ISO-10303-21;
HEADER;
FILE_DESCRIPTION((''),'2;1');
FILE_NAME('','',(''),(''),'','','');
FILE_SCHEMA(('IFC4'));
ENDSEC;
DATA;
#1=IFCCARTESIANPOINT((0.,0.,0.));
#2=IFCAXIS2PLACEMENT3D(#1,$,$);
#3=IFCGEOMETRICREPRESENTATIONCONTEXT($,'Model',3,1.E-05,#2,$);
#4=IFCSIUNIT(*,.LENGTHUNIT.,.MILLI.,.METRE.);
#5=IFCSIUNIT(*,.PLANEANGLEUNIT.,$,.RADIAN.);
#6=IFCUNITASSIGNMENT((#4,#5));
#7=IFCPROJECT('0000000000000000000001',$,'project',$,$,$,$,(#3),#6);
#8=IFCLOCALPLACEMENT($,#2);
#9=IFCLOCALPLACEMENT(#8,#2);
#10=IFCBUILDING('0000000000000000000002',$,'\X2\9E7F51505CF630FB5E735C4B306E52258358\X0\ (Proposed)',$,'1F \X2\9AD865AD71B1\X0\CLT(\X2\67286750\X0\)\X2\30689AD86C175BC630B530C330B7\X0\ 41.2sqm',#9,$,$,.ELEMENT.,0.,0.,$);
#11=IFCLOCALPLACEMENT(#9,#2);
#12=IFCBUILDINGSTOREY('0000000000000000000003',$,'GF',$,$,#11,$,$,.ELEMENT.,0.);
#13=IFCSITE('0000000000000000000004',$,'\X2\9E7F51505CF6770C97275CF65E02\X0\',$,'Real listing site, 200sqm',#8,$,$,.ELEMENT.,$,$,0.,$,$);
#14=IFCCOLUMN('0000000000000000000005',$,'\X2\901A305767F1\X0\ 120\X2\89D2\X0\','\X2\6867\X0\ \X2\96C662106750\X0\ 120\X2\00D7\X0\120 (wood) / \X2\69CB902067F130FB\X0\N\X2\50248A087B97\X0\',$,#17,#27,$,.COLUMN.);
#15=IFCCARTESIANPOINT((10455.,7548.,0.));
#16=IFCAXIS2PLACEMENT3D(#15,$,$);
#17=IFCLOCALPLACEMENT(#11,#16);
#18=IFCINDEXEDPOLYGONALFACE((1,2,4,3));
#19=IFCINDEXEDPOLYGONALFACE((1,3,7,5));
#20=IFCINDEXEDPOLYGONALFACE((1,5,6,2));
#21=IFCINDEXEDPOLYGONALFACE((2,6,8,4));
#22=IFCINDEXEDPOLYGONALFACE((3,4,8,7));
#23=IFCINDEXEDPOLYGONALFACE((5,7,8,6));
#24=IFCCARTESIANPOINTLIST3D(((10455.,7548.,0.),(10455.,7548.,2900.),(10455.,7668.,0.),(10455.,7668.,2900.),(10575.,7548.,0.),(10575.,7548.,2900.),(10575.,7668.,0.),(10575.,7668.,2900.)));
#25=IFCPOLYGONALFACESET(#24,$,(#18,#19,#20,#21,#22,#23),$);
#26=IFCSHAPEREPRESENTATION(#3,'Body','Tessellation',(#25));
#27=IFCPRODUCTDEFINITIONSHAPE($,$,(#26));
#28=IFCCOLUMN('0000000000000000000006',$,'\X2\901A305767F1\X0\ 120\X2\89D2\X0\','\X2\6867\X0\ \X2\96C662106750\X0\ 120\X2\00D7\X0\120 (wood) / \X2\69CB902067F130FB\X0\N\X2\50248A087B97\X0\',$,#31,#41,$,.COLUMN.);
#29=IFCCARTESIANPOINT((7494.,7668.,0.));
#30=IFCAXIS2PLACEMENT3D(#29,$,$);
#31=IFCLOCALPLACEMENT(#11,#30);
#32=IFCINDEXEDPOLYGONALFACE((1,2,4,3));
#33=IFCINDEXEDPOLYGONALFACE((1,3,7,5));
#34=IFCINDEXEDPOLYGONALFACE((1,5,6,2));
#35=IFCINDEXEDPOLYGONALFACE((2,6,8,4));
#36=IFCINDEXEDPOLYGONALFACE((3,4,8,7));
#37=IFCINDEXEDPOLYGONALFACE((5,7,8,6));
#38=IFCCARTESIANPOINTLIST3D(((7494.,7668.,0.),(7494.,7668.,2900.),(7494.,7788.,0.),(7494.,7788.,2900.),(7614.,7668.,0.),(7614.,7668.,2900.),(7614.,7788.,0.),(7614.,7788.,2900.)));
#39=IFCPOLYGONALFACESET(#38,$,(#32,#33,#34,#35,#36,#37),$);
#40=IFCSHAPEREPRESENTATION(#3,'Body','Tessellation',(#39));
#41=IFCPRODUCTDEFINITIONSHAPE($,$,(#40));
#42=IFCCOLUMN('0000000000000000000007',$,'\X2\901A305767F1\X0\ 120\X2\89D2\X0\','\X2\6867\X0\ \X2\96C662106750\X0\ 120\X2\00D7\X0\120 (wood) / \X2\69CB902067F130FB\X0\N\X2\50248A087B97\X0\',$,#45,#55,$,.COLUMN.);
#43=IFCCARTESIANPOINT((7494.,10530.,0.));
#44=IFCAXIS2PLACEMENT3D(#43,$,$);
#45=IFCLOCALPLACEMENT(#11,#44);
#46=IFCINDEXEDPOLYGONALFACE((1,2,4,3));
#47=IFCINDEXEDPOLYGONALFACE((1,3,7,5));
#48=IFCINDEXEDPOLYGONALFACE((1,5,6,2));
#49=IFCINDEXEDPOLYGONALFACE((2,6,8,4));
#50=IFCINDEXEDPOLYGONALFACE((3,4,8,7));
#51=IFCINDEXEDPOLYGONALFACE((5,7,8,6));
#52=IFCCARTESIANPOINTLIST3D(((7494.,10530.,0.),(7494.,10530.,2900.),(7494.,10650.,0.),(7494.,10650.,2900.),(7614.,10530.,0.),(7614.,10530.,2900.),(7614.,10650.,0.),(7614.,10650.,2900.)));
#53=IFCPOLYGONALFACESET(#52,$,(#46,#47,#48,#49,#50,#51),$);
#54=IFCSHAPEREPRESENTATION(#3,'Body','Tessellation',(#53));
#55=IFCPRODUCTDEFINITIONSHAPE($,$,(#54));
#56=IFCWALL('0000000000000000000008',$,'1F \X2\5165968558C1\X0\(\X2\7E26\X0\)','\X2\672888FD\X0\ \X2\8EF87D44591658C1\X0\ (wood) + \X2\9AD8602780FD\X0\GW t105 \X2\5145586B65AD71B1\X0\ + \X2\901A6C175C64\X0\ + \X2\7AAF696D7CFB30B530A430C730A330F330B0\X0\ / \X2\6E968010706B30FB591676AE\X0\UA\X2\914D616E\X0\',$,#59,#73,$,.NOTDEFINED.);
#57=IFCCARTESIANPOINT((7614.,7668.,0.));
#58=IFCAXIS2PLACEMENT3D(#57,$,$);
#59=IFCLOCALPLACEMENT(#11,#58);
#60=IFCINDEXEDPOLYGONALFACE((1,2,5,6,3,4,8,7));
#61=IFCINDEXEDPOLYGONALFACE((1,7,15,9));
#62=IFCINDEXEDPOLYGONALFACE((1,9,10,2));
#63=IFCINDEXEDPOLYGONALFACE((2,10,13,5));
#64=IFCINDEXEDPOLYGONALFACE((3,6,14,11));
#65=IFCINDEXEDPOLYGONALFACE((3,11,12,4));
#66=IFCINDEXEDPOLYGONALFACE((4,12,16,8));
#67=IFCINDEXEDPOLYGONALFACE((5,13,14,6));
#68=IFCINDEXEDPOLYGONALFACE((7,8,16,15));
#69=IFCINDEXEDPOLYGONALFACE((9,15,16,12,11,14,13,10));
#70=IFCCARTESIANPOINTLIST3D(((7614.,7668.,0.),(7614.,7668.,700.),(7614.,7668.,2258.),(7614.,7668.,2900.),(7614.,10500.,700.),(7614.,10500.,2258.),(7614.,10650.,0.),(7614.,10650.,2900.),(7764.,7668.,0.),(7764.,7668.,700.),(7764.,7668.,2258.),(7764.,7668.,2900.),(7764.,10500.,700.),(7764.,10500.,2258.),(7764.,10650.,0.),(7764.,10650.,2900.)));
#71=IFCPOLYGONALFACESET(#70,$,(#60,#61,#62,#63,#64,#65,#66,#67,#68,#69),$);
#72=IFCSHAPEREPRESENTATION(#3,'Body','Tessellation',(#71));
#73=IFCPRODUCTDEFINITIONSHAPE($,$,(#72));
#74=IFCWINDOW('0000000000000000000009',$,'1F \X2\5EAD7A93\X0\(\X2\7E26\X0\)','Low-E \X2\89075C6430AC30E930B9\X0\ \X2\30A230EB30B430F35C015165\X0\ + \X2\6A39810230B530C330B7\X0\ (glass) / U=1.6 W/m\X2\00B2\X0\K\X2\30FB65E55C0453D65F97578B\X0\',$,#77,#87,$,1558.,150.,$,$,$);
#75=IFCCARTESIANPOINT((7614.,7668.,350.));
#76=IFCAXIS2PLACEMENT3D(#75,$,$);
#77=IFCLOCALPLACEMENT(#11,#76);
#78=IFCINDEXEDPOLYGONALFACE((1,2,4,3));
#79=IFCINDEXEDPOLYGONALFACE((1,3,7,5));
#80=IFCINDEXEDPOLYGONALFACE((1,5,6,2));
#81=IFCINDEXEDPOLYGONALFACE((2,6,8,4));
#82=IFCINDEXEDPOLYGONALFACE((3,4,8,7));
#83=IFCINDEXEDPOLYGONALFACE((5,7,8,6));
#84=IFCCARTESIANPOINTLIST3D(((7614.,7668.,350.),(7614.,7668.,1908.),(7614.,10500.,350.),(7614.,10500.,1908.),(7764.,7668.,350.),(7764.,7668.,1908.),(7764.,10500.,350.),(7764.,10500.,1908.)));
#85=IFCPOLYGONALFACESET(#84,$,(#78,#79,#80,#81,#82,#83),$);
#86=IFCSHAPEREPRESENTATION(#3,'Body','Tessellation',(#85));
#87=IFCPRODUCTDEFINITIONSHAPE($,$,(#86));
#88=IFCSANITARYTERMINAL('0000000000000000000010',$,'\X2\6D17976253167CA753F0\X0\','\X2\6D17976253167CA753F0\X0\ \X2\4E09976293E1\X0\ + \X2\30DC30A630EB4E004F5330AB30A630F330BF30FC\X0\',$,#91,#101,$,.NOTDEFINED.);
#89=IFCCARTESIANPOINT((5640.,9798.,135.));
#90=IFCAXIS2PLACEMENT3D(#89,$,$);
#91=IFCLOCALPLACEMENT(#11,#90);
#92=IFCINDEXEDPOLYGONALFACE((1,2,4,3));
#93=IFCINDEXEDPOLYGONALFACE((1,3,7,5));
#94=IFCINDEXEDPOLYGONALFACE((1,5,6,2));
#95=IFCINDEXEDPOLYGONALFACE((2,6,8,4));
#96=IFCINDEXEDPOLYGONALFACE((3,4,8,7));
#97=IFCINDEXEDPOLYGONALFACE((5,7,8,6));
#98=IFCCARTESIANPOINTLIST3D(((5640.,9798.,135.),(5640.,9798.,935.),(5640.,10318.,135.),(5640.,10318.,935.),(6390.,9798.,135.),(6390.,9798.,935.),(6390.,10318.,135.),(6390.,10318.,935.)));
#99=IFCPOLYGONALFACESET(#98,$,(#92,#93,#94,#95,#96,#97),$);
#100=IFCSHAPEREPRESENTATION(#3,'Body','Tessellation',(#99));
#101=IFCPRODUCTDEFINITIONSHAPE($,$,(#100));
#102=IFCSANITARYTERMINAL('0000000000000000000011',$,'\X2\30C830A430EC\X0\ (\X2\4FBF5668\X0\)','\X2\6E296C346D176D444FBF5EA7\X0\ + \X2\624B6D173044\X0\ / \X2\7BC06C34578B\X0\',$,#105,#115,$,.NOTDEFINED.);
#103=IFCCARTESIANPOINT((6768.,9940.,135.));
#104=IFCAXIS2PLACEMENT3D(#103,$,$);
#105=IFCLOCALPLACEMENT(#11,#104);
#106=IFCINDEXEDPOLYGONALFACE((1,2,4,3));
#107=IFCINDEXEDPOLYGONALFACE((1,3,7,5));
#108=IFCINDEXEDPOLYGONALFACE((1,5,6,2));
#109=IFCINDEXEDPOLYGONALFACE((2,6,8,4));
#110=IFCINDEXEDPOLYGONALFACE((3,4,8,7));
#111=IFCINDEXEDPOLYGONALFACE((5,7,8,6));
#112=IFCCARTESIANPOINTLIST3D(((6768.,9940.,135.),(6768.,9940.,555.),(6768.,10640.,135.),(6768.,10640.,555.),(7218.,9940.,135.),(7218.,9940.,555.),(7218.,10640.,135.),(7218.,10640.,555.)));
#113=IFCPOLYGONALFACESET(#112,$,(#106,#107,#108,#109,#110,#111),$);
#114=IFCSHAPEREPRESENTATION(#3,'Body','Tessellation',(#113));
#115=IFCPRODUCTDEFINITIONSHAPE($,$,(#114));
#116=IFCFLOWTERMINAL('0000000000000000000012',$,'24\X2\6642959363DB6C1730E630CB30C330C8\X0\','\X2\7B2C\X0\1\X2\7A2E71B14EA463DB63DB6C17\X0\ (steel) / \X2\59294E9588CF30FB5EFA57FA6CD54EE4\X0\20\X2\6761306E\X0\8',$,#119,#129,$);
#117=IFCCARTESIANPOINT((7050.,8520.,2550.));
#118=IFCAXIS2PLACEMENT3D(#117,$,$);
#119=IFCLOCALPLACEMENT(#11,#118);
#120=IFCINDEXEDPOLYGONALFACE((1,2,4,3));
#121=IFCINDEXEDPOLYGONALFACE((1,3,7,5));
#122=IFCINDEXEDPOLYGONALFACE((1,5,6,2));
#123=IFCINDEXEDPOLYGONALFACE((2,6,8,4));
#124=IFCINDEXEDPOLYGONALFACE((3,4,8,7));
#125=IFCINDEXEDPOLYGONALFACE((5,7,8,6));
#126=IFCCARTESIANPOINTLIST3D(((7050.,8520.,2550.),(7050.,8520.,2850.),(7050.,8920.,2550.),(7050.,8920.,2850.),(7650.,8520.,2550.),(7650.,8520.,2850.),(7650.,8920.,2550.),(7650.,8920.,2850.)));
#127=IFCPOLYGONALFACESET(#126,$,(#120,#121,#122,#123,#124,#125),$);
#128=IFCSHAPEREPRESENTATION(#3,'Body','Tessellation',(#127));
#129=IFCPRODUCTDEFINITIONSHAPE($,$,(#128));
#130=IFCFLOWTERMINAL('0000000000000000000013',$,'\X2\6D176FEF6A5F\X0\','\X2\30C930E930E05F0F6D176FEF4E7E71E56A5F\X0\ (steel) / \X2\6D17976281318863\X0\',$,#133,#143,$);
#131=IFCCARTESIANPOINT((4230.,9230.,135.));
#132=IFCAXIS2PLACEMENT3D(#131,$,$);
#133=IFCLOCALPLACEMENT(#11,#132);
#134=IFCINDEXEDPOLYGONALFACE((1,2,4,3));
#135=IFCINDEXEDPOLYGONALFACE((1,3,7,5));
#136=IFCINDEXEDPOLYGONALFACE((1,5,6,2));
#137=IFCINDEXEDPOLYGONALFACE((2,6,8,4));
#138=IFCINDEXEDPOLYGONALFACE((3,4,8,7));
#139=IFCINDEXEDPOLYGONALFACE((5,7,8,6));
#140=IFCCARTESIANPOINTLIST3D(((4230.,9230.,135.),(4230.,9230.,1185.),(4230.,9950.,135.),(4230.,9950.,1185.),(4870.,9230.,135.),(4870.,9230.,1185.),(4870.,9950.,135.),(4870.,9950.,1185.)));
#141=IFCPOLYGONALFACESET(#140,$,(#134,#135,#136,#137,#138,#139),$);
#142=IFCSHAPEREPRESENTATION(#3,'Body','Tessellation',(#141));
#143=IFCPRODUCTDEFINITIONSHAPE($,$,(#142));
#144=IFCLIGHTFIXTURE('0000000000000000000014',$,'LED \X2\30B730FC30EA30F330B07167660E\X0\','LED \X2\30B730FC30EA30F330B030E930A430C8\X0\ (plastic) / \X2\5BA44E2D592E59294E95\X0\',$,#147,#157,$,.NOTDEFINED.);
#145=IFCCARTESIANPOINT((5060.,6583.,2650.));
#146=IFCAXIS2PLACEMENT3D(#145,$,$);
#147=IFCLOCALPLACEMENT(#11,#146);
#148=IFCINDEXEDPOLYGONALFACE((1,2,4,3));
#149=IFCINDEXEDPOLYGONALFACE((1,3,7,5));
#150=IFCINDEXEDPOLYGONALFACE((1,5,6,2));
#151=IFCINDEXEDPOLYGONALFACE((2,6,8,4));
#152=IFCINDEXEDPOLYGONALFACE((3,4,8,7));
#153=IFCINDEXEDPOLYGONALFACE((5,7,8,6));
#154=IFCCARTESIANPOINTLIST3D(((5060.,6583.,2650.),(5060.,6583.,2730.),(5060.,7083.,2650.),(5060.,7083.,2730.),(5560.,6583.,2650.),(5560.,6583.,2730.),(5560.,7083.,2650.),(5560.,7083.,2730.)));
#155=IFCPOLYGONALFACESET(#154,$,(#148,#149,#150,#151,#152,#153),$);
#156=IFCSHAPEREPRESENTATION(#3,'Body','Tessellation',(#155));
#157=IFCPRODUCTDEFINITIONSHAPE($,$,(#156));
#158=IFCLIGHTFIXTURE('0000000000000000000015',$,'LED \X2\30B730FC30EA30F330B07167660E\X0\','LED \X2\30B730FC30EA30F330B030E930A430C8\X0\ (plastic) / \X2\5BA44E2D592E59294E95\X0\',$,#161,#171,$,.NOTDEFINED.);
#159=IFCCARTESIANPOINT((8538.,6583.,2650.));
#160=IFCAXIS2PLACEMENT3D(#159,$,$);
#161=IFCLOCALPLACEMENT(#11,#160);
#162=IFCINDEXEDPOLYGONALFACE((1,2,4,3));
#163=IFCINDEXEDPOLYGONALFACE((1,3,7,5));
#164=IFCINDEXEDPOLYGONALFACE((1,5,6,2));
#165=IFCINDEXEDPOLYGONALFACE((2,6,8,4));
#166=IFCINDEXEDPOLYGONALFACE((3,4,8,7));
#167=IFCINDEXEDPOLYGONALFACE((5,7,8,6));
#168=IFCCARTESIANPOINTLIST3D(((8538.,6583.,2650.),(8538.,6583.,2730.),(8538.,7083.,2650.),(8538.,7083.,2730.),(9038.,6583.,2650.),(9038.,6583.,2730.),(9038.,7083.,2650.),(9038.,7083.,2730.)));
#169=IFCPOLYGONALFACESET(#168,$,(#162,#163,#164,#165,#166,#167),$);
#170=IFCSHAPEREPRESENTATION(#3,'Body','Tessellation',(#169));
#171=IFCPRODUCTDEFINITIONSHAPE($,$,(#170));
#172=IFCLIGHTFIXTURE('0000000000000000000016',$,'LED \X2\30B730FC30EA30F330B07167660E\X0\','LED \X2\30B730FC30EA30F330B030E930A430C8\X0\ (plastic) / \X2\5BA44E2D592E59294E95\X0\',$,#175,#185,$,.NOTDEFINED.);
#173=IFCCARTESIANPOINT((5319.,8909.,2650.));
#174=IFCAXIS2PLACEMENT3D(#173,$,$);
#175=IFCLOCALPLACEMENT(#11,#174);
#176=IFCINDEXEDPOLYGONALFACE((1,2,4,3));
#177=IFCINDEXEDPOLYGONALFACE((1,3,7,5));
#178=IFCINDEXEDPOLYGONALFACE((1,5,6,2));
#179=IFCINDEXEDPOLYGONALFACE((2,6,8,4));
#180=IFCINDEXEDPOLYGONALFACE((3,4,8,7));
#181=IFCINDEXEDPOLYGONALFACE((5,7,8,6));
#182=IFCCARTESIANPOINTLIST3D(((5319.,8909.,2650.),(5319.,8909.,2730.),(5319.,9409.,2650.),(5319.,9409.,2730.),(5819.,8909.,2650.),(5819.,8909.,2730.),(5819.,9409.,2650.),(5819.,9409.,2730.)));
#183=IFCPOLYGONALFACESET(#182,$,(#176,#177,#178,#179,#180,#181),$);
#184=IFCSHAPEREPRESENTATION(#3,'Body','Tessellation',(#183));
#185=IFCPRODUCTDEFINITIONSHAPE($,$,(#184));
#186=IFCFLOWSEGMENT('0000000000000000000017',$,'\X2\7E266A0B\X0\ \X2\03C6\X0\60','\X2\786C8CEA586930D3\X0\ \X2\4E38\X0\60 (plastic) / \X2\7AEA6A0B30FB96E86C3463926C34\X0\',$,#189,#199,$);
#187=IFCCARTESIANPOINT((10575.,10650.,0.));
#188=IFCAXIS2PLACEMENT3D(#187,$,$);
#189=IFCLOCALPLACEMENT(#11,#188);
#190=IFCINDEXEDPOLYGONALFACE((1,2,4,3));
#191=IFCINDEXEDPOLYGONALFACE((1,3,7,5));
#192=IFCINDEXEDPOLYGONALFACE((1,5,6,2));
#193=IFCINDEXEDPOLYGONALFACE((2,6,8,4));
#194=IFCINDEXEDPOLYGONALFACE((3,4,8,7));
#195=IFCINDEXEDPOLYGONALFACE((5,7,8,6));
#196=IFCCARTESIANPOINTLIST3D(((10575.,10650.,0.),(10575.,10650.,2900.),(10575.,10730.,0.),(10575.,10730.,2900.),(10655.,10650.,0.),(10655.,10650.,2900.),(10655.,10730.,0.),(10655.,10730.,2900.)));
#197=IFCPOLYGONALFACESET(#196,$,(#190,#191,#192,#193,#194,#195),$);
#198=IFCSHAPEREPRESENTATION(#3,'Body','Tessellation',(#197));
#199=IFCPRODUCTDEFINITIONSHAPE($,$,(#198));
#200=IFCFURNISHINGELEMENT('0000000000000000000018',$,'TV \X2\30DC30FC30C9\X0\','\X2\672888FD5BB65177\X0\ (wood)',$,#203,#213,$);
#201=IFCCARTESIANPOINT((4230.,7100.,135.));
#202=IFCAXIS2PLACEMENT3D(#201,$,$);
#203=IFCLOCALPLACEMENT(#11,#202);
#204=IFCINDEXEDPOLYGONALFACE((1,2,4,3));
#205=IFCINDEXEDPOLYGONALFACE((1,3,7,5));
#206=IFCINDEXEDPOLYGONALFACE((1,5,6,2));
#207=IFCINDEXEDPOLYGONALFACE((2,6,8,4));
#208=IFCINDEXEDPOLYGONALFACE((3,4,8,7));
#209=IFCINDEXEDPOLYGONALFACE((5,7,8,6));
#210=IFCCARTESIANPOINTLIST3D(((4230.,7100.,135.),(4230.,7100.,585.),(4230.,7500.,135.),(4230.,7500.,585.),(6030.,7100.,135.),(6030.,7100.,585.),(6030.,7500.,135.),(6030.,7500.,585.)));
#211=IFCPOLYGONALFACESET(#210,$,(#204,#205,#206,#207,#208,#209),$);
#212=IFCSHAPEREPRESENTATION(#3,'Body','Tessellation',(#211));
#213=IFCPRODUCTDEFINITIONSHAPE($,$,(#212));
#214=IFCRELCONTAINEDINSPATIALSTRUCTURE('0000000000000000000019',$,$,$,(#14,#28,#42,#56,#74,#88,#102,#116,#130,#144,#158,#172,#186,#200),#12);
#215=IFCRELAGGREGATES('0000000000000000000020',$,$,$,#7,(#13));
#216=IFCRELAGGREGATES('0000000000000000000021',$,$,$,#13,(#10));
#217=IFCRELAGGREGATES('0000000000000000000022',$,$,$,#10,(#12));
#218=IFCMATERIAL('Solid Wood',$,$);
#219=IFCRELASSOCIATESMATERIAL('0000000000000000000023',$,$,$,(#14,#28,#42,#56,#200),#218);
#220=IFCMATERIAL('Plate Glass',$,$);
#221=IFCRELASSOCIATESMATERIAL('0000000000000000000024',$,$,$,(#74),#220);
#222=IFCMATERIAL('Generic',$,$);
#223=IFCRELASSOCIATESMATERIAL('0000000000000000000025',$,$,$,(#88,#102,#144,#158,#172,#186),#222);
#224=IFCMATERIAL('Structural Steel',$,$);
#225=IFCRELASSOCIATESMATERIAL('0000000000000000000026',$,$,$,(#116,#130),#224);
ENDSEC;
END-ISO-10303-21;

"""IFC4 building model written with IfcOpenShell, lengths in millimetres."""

from ifc_helpers import new_model, si_unit, frame, frame_2d, origin, place, context, project, spatial, rectangle, extrude, material, element, fill, save


model = new_model("IFC4")

# Units and contexts
model_context = context("Model", 3, precision=1e-05, world=origin())
ifc_project = project(units=[si_unit("LENGTHUNIT", "METRE", prefix="MILLI"), si_unit("PLANEANGLEUNIT", "RADIAN")], contexts=[model_context])

# Site, building, storey
site_placement = place(None, origin())
site = spatial("IfcSite", under=ifc_project, at=site_placement, Name="鹿児島県霧島市", ObjectType="Real listing site, 200sqm", CompositionType="ELEMENT", RefElevation=0.0)
building_placement = place(site_placement, origin())
building = spatial("IfcBuilding", under=site, at=building_placement, Name="鹿児島・平屋の別荘 (Proposed)", ObjectType="1F 高断熱CLT(木材)と高気密サッシ 41.2sqm", CompositionType="ELEMENT", ElevationOfRefHeight=0.0, ElevationOfTerrain=0.0)
storey_placement = place(building_placement, origin())
storey = spatial("IfcBuildingStorey", under=building, at=storey_placement, Name="GF", CompositionType="ELEMENT", Elevation=0.0)

# Columns
ifc_material_1 = material(Name="Solid Wood")
column_1_placement = place(storey_placement, frame((10455.0, 7548.0, 0.0)))
element("IfcColumn", 1, at=column_1_placement, inside=storey, material=ifc_material_1, Name="通し柱 120角", Description="桧 集成材 120×120 (wood) / 構造柱・N値計算", PredefinedType="COLUMN", context=model_context, shape_type="SweptSolid", body=[
    extrude(rectangle(XDim=120.0, YDim=120.0, at=frame_2d((60.0, 60.0))), frame((10455.0, 7548.0, 0.0)), (0.0, 0.0, 1.0), 2900.0),
])
column_2_placement = place(storey_placement, frame((7494.0, 7668.0, 0.0)))
element("IfcColumn", 2, at=column_2_placement, inside=storey, material=ifc_material_1, Name="通し柱 120角", Description="桧 集成材 120×120 (wood) / 構造柱・N値計算", PredefinedType="COLUMN", context=model_context, shape_type="SweptSolid", body=[
    extrude(rectangle(XDim=120.0, YDim=120.0, at=frame_2d((60.0, 60.0))), frame((7494.0, 7668.0, 0.0)), (0.0, 0.0, 1.0), 2900.0),
])
column_3_placement = place(storey_placement, frame((7494.0, 10530.0, 0.0)))
element("IfcColumn", 3, at=column_3_placement, inside=storey, material=ifc_material_1, Name="通し柱 120角", Description="桧 集成材 120×120 (wood) / 構造柱・N値計算", PredefinedType="COLUMN", context=model_context, shape_type="SweptSolid", body=[
    extrude(rectangle(XDim=120.0, YDim=120.0, at=frame_2d((60.0, 60.0))), frame((7494.0, 10530.0, 0.0)), (0.0, 0.0, 1.0), 2900.0),
])

# Wall, opening, window
wall_1_placement = place(storey_placement, frame((7614.0, 7668.0, 0.0)))
wall_1 = element("IfcWall", 4, at=wall_1_placement, inside=storey, material=ifc_material_1, Name="1F 入隅壁(縦)", Description="木製 軸組外壁 (wood) + 高性能GW t105 充填断熱 + 通気層 + 窯業系サイディング / 準耐火・外皮UA配慮", PredefinedType="NOTDEFINED", context=model_context, shape_type="SweptSolid", body=[
    extrude(rectangle(XDim=150.0, YDim=2982.0, at=frame_2d((75.0, 1491.0))), frame((7614.0, 7668.0, 0.0)), (0.0, 0.0, 1.0), 2900.0),
])
opening_placement = place(storey_placement, frame((7614.0, 7668.0, 350.0)))
opening = element("IfcOpeningElement", 5, at=opening_placement, cuts=wall_1, PredefinedType="NOTDEFINED", context=model_context, shape_type="SweptSolid", body=[
    extrude(rectangle(XDim=150.0, YDim=2832.0, at=frame_2d((75.0, 1416.0))), frame((7614.0, 7668.0, 350.0)), (0.0, 0.0, 1.0), 1558.0),
])
ifc_material_2 = material(Name="Plate Glass")
window_placement = place(storey_placement, frame((7614.0, 7668.0, 350.0)))
window = element("IfcWindow", 6, at=window_placement, inside=storey, material=ifc_material_2, Name="1F 庭窓(縦)", Description="Low-E 複層ガラス アルゴン封入 + 樹脂サッシ (glass) / U=1.6 W/m²K・日射取得型", OverallHeight=1558.0, OverallWidth=150.0, context=model_context, shape_type="SweptSolid", body=[
    extrude(rectangle(XDim=150.0, YDim=2832.0, at=frame_2d((75.0, 1416.0))), frame((7614.0, 7668.0, 350.0)), (0.0, 0.0, 1.0), 1558.0),
])
fill(opening, window)

# Sanitary terminals
ifc_material_3 = material(Name="Generic")
sanitary_terminal_1_placement = place(storey_placement, frame((5640.0, 9798.0, 135.0)))
element("IfcSanitaryTerminal", 7, at=sanitary_terminal_1_placement, inside=storey, material=ifc_material_3, Name="洗面化粧台", Description="洗面化粧台 三面鏡 + ボウル一体カウンター", PredefinedType="NOTDEFINED", context=model_context, shape_type="SweptSolid", body=[
    extrude(rectangle(XDim=750.0, YDim=520.0, at=frame_2d((375.0, 260.0))), frame((5640.0, 9798.0, 135.0)), (0.0, 0.0, 1.0), 800.0),
])
sanitary_terminal_2_placement = place(storey_placement, frame((6768.0, 9940.0, 135.0)))
element("IfcSanitaryTerminal", 8, at=sanitary_terminal_2_placement, inside=storey, material=ifc_material_3, Name="トイレ (便器)", Description="温水洗浄便座 + 手洗い / 節水型", PredefinedType="NOTDEFINED", context=model_context, shape_type="SweptSolid", body=[
    extrude(rectangle(XDim=450.0, YDim=700.0, at=frame_2d((225.0, 350.0))), frame((6768.0, 9940.0, 135.0)), (0.0, 0.0, 1.0), 420.0),
])

# Flow terminals
ifc_material_4 = material(Name="Structural Steel")
flow_terminal_1_placement = place(storey_placement, frame((7050.0, 8520.0, 2550.0)))
element("IfcFlowTerminal", 9, at=flow_terminal_1_placement, inside=storey, material=ifc_material_4, Name="24時間換気ユニット", Description="第1種熱交換換気 (steel) / 天井裏・建基法令20条の8", context=model_context, shape_type="SweptSolid", body=[
    extrude(rectangle(XDim=600.0, YDim=400.0, at=frame_2d((300.0, 200.0))), frame((7050.0, 8520.0, 2550.0)), (0.0, 0.0, 1.0), 300.0),
])
flow_terminal_2_placement = place(storey_placement, frame((4230.0, 9230.0, 135.0)))
element("IfcFlowTerminal", 10, at=flow_terminal_2_placement, inside=storey, material=ifc_material_4, Name="洗濯機", Description="ドラム式洗濯乾燥機 (steel) / 洗面脱衣", context=model_context, shape_type="SweptSolid", body=[
    extrude(rectangle(XDim=640.0, YDim=720.0, at=frame_2d((320.0, 360.0))), frame((4230.0, 9230.0, 135.0)), (0.0, 0.0, 1.0), 1050.0),
])

# Light fixtures
light_fixture_1_placement = place(storey_placement, frame((5060.0, 6583.0, 2650.0)))
element("IfcLightFixture", 11, at=light_fixture_1_placement, inside=storey, material=ifc_material_3, Name="LED シーリング照明", Description="LED シーリングライト (plastic) / 室中央天井", PredefinedType="NOTDEFINED", context=model_context, shape_type="SweptSolid", body=[
    extrude(rectangle(XDim=500.0, YDim=500.0, at=frame_2d((250.0, 250.0))), frame((5060.0, 6583.0, 2650.0)), (0.0, 0.0, 1.0), 80.0),
])
light_fixture_2_placement = place(storey_placement, frame((8538.0, 6583.0, 2650.0)))
element("IfcLightFixture", 12, at=light_fixture_2_placement, inside=storey, material=ifc_material_3, Name="LED シーリング照明", Description="LED シーリングライト (plastic) / 室中央天井", PredefinedType="NOTDEFINED", context=model_context, shape_type="SweptSolid", body=[
    extrude(rectangle(XDim=500.0, YDim=500.0, at=frame_2d((250.0, 250.0))), frame((8538.0, 6583.0, 2650.0)), (0.0, 0.0, 1.0), 80.0),
])
light_fixture_3_placement = place(storey_placement, frame((5319.0, 8909.0, 2650.0)))
element("IfcLightFixture", 13, at=light_fixture_3_placement, inside=storey, material=ifc_material_3, Name="LED シーリング照明", Description="LED シーリングライト (plastic) / 室中央天井", PredefinedType="NOTDEFINED", context=model_context, shape_type="SweptSolid", body=[
    extrude(rectangle(XDim=500.0, YDim=500.0, at=frame_2d((250.0, 250.0))), frame((5319.0, 8909.0, 2650.0)), (0.0, 0.0, 1.0), 80.0),
])

# Flow segment
flow_segment_placement = place(storey_placement, frame((10575.0, 10650.0, 0.0)))
element("IfcFlowSegment", 14, at=flow_segment_placement, inside=storey, material=ifc_material_3, Name="縦樋 φ60", Description="硬質塩ビ 丸60 (plastic) / 竪樋・雨水排水", context=model_context, shape_type="SweptSolid", body=[
    extrude(rectangle(XDim=80.0, YDim=80.0, at=frame_2d((40.0, 40.0))), frame((10575.0, 10650.0, 0.0)), (0.0, 0.0, 1.0), 2900.0),
])

# Furnishing element
furnishing_placement = place(storey_placement, frame((4230.0, 7100.0, 135.0)))
element("IfcFurnishingElement", 15, at=furnishing_placement, inside=storey, material=ifc_material_1, Name="TV ボード", Description="木製家具 (wood)", context=model_context, shape_type="SweptSolid", body=[
    extrude(rectangle(XDim=1800.0, YDim=400.0, at=frame_2d((900.0, 200.0))), frame((4230.0, 7100.0, 135.0)), (0.0, 0.0, 1.0), 450.0),
])

save(model, "model.ifc")
